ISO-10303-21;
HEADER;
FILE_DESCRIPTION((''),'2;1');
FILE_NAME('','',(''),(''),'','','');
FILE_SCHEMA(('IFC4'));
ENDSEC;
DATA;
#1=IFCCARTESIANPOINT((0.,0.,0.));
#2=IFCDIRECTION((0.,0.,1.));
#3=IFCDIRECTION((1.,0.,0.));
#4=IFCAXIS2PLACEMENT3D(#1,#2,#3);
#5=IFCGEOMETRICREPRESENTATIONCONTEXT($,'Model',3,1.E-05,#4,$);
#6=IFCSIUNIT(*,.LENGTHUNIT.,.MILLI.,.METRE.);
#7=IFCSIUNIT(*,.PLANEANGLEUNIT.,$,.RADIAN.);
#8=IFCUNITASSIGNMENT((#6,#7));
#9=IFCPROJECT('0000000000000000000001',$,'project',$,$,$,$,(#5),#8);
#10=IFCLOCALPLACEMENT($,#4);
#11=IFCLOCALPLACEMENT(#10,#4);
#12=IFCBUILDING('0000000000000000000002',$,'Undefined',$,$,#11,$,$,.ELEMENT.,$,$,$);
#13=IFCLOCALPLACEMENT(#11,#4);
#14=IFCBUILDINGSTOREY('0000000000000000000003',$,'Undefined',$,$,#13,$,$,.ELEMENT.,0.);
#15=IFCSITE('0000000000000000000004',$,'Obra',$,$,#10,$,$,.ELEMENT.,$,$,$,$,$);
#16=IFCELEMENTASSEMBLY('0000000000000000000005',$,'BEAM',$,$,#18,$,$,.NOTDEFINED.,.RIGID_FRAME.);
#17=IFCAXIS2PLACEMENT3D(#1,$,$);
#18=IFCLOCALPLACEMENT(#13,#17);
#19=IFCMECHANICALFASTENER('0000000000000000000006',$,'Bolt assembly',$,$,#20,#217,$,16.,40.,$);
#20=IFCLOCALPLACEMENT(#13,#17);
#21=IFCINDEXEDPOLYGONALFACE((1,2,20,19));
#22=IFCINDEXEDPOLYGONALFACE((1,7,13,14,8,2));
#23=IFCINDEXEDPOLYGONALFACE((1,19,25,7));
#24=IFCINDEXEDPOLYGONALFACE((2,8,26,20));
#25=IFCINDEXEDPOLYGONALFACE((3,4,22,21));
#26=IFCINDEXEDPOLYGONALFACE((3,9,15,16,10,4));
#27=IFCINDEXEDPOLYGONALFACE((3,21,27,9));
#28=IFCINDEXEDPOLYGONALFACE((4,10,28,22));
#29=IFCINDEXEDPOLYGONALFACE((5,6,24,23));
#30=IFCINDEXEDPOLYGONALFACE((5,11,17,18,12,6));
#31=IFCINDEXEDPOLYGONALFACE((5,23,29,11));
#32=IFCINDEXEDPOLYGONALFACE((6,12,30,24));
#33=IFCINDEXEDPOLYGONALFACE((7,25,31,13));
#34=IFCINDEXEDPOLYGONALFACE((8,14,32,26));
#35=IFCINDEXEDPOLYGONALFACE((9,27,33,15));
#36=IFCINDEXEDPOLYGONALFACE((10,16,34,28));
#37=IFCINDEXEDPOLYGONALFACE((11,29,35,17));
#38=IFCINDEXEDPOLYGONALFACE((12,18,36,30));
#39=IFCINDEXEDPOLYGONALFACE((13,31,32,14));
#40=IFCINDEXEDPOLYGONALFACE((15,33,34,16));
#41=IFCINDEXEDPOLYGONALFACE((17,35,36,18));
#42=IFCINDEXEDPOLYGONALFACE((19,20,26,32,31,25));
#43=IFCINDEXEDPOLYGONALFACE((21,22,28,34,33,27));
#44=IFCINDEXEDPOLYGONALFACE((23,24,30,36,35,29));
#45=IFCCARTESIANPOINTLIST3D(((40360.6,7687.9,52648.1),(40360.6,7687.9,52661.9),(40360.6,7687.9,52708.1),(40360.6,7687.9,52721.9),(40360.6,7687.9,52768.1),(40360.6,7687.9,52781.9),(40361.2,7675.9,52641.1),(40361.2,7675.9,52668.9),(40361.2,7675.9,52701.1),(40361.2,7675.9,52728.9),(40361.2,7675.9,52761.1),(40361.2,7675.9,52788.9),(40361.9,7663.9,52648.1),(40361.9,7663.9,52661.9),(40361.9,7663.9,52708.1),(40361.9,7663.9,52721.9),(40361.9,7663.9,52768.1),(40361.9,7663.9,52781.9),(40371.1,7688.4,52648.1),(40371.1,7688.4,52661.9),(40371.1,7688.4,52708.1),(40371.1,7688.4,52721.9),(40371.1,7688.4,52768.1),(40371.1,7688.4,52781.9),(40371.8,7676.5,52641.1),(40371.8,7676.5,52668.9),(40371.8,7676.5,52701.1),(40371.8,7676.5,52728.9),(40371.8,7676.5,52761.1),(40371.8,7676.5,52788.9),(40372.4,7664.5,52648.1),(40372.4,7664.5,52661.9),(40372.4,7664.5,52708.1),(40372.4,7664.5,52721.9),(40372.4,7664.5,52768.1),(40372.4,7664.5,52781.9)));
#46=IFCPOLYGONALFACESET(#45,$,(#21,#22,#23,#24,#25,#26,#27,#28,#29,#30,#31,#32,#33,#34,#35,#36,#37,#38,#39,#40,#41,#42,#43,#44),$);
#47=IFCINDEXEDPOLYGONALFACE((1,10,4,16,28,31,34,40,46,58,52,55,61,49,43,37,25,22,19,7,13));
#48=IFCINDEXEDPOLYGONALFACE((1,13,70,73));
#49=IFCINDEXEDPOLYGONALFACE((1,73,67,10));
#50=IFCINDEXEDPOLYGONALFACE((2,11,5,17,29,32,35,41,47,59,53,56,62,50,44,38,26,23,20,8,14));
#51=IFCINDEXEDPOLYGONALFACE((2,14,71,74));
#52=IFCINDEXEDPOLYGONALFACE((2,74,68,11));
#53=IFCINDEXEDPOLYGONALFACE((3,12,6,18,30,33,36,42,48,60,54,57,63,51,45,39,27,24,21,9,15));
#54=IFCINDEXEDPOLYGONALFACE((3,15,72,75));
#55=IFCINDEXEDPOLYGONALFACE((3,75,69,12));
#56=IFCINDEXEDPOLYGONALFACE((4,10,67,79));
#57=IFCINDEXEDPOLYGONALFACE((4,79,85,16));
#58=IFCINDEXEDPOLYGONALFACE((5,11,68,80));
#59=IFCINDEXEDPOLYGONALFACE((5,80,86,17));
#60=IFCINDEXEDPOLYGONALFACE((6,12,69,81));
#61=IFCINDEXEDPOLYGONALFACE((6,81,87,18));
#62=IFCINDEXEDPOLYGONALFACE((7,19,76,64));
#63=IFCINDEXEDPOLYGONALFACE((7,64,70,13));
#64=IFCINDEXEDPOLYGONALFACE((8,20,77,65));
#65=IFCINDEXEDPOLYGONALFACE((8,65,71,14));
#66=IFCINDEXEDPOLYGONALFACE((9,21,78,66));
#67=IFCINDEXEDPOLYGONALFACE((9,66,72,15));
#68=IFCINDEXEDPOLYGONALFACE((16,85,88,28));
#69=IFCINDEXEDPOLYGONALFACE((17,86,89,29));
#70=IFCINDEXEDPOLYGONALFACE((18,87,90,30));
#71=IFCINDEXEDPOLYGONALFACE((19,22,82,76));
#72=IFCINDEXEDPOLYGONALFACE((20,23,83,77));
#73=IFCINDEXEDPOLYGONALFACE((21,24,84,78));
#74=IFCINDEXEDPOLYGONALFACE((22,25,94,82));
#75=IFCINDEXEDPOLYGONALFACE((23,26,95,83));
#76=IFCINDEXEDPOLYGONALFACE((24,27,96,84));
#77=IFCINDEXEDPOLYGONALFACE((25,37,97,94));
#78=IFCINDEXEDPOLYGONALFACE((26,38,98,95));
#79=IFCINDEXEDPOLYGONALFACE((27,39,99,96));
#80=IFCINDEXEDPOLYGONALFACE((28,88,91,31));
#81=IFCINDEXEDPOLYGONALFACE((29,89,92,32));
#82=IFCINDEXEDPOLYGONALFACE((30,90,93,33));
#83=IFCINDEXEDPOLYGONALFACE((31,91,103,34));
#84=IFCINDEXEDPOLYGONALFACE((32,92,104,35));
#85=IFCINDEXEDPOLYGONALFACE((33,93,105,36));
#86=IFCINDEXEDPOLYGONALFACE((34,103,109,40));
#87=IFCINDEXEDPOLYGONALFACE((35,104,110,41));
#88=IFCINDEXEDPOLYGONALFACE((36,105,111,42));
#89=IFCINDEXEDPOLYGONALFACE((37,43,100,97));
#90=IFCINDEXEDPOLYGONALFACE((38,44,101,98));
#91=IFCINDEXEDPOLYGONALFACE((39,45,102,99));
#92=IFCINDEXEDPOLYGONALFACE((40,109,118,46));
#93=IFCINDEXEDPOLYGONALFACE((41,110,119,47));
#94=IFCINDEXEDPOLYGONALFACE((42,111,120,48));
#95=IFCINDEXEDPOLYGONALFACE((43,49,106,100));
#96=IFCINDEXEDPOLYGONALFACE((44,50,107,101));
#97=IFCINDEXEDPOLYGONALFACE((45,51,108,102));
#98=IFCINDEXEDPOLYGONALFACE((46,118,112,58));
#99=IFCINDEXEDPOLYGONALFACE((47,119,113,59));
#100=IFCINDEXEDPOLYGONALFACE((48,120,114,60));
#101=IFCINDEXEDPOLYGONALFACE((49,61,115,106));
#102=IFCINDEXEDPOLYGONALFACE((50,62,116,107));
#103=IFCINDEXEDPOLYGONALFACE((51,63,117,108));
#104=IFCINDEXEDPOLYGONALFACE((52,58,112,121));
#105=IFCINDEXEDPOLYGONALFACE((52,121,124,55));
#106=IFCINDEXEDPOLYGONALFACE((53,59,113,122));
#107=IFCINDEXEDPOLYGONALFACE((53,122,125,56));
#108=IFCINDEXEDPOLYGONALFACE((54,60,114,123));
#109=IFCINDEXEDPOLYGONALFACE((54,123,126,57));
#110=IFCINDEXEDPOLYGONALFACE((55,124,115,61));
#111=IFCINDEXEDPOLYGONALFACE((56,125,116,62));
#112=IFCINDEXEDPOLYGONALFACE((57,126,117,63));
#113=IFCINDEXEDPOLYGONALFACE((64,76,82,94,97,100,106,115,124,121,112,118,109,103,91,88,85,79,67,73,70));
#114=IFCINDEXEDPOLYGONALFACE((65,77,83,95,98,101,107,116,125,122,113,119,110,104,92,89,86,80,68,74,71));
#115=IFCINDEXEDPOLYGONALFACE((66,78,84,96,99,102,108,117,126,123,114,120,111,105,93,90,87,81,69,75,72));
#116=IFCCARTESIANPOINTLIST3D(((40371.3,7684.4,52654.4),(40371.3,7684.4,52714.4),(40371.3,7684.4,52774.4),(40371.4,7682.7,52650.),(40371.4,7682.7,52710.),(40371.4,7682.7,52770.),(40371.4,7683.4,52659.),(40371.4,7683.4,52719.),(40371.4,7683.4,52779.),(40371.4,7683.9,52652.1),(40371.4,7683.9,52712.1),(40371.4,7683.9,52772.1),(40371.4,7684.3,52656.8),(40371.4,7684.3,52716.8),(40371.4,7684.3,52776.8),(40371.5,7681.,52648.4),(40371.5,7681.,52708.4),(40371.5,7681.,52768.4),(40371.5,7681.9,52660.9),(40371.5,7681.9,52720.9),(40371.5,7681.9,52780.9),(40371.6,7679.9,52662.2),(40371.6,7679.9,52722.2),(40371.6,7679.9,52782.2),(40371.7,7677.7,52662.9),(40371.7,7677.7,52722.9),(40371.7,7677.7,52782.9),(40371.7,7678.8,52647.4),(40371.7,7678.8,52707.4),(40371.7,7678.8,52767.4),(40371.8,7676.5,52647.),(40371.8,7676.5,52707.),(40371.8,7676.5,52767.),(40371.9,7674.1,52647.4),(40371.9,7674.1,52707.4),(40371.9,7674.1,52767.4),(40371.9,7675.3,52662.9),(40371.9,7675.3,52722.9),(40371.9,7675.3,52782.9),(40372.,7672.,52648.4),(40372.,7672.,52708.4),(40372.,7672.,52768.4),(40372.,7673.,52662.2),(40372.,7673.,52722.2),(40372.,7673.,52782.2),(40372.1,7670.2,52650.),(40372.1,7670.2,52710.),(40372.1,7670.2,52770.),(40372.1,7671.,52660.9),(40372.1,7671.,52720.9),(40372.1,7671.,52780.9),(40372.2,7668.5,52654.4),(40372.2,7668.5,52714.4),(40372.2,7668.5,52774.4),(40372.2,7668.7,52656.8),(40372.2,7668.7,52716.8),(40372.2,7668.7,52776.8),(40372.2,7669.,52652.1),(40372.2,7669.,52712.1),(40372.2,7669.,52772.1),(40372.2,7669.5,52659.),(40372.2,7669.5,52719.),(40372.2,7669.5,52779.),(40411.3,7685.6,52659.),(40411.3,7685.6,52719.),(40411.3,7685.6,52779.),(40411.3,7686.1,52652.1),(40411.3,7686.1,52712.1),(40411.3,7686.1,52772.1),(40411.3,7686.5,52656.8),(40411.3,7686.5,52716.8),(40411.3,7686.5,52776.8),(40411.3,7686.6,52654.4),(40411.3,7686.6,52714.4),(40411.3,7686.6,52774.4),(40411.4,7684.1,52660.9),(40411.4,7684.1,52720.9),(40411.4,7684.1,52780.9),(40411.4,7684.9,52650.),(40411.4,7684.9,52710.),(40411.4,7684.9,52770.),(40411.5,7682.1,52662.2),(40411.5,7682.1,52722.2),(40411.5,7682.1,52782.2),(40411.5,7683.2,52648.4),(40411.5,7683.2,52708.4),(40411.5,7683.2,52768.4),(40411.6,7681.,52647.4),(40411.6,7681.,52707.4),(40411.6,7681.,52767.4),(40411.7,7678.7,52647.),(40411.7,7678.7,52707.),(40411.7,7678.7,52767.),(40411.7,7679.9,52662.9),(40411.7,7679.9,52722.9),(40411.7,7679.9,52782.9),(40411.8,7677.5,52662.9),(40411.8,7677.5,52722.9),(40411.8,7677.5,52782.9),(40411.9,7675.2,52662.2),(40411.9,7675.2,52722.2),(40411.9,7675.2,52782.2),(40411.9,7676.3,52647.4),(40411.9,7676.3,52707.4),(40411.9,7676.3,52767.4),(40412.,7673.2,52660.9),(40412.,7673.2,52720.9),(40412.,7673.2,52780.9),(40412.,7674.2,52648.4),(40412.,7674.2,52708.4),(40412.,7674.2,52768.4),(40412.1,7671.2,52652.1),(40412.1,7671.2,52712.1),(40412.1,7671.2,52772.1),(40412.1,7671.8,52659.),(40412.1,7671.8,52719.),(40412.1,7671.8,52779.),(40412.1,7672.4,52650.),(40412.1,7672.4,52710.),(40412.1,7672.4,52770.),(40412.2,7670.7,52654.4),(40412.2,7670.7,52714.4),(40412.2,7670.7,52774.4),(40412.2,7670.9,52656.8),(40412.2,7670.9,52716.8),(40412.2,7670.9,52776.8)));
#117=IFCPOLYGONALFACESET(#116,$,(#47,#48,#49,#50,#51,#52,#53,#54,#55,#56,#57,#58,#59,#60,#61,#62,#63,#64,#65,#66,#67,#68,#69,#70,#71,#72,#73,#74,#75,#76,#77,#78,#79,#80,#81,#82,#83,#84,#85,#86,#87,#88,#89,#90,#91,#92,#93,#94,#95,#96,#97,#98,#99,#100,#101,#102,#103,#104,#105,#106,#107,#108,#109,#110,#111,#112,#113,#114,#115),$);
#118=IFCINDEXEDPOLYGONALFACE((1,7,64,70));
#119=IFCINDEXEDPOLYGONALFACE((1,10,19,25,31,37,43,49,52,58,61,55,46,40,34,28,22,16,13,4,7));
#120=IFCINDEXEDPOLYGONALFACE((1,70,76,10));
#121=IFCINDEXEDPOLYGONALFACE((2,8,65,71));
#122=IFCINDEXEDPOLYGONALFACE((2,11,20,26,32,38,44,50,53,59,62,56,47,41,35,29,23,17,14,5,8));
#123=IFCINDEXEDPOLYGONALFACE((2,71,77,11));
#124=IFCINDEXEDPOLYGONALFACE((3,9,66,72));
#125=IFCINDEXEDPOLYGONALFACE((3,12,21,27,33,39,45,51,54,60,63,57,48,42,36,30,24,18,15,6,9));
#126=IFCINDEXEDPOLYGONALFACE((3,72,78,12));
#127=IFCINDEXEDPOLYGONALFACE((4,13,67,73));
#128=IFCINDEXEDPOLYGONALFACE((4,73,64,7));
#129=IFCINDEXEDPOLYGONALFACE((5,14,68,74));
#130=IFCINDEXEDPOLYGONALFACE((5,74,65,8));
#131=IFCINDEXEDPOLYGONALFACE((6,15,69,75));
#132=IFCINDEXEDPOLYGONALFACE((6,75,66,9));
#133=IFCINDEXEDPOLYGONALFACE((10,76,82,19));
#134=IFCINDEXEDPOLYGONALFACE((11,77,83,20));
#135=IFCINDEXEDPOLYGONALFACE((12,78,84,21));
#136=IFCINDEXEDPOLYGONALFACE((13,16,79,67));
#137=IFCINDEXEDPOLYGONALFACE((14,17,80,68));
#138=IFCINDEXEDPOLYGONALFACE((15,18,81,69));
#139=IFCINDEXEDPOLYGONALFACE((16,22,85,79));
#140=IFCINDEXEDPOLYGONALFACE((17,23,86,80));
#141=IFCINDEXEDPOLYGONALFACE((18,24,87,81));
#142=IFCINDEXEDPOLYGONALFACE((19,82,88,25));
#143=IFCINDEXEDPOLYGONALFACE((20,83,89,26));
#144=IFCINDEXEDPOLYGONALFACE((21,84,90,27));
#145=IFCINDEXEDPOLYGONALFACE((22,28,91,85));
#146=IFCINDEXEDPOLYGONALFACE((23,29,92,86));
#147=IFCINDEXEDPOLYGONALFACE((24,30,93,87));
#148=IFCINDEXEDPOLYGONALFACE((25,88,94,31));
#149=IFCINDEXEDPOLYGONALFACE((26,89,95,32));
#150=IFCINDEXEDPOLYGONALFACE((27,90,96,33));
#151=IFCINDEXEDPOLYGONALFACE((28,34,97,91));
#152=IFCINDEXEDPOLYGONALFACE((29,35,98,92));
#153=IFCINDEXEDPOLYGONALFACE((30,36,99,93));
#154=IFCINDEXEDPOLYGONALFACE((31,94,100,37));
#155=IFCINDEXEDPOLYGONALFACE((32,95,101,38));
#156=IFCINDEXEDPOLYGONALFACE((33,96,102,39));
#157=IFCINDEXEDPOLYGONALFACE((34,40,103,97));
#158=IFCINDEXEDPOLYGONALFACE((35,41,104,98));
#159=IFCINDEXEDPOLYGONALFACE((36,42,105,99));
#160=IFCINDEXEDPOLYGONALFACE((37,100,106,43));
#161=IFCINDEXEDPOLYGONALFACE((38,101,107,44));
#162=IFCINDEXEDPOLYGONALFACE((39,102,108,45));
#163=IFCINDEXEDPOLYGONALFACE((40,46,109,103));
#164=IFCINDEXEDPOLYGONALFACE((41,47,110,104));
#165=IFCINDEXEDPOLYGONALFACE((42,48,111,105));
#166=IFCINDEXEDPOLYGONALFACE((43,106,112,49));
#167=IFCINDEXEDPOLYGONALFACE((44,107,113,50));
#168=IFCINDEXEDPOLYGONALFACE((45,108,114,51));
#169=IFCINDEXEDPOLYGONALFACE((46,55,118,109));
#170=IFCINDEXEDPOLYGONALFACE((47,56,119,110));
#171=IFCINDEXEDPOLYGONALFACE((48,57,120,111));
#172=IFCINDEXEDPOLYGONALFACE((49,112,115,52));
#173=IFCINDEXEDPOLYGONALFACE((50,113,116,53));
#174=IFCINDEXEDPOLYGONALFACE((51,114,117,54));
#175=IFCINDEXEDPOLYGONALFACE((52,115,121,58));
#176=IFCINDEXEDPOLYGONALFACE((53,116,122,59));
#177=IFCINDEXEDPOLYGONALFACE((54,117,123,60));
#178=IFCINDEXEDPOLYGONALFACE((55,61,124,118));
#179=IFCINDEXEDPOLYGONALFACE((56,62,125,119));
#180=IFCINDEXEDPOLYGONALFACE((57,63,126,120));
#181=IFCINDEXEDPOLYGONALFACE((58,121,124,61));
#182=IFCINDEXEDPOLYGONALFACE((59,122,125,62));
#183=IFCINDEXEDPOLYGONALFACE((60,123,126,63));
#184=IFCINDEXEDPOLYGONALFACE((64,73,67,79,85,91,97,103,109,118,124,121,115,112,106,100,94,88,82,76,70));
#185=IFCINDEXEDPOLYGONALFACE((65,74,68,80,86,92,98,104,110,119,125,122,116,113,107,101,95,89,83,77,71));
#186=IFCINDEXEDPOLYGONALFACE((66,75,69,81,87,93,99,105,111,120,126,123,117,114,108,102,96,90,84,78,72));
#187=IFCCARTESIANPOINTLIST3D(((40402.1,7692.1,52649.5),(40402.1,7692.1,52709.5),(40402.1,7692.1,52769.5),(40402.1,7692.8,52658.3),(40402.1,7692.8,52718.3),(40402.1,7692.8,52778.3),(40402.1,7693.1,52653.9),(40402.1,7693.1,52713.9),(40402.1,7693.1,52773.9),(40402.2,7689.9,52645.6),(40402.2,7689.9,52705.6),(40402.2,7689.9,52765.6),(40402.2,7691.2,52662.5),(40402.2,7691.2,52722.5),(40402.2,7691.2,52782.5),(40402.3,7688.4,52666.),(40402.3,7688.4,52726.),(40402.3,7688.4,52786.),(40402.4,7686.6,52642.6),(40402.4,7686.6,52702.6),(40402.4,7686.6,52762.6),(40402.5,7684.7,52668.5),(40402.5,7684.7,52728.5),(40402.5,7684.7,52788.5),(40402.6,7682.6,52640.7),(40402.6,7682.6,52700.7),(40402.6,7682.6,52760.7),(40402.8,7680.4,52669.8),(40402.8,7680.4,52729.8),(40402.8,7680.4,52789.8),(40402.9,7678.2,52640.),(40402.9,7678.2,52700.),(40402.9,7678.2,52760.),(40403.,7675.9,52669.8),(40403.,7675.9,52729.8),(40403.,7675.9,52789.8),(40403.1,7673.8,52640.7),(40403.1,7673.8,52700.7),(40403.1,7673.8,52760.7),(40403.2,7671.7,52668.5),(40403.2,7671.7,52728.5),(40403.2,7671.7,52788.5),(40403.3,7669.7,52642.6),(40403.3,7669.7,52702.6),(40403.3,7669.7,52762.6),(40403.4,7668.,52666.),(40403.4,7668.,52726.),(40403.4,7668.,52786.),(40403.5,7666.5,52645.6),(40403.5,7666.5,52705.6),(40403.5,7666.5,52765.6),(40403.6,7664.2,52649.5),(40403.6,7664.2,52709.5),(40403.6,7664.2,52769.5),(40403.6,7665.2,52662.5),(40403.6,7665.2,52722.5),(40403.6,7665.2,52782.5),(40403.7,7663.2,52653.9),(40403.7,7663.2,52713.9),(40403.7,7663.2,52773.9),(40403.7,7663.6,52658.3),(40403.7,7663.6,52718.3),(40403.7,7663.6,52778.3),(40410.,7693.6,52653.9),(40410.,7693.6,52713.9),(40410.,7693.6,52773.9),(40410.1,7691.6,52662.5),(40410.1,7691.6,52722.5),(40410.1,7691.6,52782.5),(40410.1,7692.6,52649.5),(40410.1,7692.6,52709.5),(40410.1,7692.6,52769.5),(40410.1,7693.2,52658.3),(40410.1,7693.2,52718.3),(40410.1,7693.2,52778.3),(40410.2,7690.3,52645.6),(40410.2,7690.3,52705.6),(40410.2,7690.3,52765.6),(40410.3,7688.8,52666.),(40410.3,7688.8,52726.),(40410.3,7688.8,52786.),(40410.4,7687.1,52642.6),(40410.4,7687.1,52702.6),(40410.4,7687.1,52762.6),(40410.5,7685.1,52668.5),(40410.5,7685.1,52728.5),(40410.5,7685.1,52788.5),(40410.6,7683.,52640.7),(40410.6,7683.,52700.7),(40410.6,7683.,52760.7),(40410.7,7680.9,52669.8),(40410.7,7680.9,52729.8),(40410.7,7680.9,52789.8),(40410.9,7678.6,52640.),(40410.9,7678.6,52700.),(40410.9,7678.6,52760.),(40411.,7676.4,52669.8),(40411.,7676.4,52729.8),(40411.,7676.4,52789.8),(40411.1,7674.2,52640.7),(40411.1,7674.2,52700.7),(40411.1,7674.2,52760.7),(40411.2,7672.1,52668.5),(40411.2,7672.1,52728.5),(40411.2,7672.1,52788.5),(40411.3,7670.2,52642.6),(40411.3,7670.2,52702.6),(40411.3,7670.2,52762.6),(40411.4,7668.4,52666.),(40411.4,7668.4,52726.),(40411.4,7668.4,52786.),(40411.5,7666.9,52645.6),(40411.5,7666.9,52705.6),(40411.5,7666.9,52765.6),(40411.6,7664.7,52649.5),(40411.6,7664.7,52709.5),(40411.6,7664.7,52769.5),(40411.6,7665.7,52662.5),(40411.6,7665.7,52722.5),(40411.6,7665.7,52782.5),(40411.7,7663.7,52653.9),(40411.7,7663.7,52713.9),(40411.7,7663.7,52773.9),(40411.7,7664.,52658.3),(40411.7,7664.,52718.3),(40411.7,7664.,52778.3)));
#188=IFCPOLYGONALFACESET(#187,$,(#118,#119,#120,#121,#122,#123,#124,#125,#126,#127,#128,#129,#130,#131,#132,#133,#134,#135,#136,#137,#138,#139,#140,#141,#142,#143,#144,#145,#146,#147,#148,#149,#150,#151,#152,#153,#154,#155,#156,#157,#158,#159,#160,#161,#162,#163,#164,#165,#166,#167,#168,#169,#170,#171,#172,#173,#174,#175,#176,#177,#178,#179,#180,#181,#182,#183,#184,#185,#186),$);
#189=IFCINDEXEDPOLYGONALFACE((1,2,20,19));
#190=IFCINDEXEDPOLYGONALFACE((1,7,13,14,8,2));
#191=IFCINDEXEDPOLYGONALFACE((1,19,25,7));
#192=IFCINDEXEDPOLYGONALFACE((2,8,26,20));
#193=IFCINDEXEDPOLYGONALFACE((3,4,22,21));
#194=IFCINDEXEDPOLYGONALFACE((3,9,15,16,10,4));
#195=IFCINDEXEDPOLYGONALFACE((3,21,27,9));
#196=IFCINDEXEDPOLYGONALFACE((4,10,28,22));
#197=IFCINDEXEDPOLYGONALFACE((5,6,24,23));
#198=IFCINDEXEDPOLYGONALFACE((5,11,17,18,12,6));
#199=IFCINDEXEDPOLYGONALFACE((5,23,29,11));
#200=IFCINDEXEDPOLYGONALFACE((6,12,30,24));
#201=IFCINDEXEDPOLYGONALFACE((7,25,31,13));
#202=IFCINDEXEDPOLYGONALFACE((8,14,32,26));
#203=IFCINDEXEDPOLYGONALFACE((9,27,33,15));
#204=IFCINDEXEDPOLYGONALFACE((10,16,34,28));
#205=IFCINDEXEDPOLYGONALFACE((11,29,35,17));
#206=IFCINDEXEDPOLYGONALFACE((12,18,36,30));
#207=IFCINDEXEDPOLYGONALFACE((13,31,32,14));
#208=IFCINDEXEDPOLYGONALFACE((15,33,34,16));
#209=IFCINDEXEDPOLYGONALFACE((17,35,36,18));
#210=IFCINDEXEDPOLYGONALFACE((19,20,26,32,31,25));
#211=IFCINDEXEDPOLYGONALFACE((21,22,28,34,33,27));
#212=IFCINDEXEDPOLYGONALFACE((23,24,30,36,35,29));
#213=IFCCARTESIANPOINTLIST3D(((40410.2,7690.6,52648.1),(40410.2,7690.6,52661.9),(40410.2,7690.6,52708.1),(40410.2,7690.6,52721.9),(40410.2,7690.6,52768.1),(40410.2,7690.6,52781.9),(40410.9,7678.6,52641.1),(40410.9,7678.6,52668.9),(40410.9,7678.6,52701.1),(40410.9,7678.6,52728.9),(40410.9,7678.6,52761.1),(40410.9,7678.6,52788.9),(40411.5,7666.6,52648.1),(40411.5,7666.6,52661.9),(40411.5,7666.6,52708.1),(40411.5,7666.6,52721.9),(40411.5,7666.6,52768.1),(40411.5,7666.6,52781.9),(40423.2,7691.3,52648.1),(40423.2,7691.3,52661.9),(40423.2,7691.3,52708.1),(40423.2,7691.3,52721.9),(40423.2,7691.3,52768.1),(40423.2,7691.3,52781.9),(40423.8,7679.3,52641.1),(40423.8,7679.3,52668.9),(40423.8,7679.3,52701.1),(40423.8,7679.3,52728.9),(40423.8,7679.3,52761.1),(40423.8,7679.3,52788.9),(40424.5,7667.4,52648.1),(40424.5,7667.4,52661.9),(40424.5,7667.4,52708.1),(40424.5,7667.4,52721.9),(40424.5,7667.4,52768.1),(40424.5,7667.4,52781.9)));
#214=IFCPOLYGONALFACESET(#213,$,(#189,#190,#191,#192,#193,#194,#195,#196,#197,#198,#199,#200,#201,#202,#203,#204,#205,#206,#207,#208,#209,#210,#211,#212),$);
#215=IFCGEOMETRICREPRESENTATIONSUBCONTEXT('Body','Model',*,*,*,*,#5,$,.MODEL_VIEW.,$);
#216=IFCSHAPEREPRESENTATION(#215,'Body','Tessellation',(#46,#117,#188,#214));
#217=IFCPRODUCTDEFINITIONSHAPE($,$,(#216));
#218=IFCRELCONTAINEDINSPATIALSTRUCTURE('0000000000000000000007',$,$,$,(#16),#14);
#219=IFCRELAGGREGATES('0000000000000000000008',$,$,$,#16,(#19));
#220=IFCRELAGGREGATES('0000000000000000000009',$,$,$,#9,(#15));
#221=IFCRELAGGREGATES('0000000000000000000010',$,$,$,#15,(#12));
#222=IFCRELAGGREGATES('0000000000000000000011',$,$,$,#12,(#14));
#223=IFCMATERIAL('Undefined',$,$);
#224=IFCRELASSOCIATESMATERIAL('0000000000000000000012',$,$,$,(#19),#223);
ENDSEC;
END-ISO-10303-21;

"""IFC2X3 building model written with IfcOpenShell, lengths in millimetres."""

from ifc_helpers import new_model, si_unit, frame, origin_with_axes, origin_2d_with_axis, place, context, subcontext, project, spatial, polyline, circle, outline, extrude, source, transform, mapped, material, element, aggregate, save


model = new_model("IFC2X3")

# Units and contexts
model_context = context("Model", 3, precision=1e-05, world=origin_with_axes())
body_context = subcontext(model_context, "Body", "Model", "MODEL_VIEW")
ifc_project = project(units=[si_unit("LENGTHUNIT", "METRE", prefix="MILLI"), si_unit("PLANEANGLEUNIT", "RADIAN")], contexts=[model_context])

# Site, building, storey
site_placement = place(None, origin_with_axes())
site = spatial("IfcSite", under=ifc_project, at=site_placement, Name="Obra", CompositionType="ELEMENT")
building_placement = place(site_placement, origin_with_axes())
building = spatial("IfcBuilding", under=site, at=building_placement, Name="Undefined", CompositionType="ELEMENT")
storey_placement = place(building_placement, origin_with_axes())
storey = spatial("IfcBuildingStorey", under=building, at=storey_placement, Name="Undefined", CompositionType="ELEMENT", Elevation=0.0)

# Element assembly
assembly_1_placement = place(storey_placement, origin_with_axes())
assembly_1 = element("IfcElementAssembly", 1, at=assembly_1_placement, inside=storey, Name="BEAM", AssemblyPlace="NOTDEFINED", PredefinedType="RIGID_FRAME")

# Shared definitions
ifc_material_1 = material(Name="Undefined")

# Mechanical fastener
shared_shape_1 = source(origin_with_axes(), body_context, "Body", "SweptSolid", [
    extrude(outline(polyline([(13.9, 0.0), (6.9, 12.0), (-6.9, 12.0), (-13.9, 0.0), (-6.9, -12.0), (6.9, -12.0), (13.9, 0.0)])), frame((0.0, -44.8, 0.0), z_axis=(0.0, 1.0, 0.0), x_axis=(1.0, 0.0, 0.0)), (0.0, 0.0, 1.0), 10.6),
    extrude(circle(Radius=8.0, at=origin_2d_with_axis()), frame((0.0, -34.2, 0.0), z_axis=(0.0, 1.0, 0.0), x_axis=(1.0, 0.0, 0.0)), (0.0, 0.0, 1.0), 40.0),
    extrude(circle(Radius=15.0, at=origin_2d_with_axis()), frame((0.0, -3.1, 0.0), z_axis=(0.0, 1.0, 0.0), x_axis=(1.0, 0.0, 0.0)), (0.0, 0.0, 1.0), 8.0),
    extrude(outline(polyline([(13.9, 0.0), (6.9, 12.0), (-6.9, 12.0), (-13.9, 0.0), (-6.9, -12.0), (6.9, -12.0), (13.9, 0.0)])), frame((0.0, 4.9, 0.0), z_axis=(0.0, 1.0, 0.0), x_axis=(1.0, 0.0, 0.0)), (0.0, 0.0, 1.0), 13.0),
])
mechanical_fastener_1_placement = place(assembly_1_placement, frame((40403.2, 7728.3, 52835.0), z_axis=(0.055152, -0.998478, 0.0), x_axis=(0.0, 0.0, -1.0)))
mechanical_fastener_1 = element("IfcMechanicalFastener", 2, at=mechanical_fastener_1_placement, material=ifc_material_1, Name="Bolt assembly", NominalDiameter=16.0, NominalLength=40.0, context=body_context, shape_type="MappedRepresentation", body=[
    mapped(shared_shape_1, transform((60.0, 0.0, 50.0))),
    mapped(shared_shape_1, transform((120.0, 0.0, 50.0))),
    mapped(shared_shape_1, transform((180.0, 0.0, 50.0))),
])
aggregate(assembly_1, [mechanical_fastener_1])

save(model, "model.ifc")
